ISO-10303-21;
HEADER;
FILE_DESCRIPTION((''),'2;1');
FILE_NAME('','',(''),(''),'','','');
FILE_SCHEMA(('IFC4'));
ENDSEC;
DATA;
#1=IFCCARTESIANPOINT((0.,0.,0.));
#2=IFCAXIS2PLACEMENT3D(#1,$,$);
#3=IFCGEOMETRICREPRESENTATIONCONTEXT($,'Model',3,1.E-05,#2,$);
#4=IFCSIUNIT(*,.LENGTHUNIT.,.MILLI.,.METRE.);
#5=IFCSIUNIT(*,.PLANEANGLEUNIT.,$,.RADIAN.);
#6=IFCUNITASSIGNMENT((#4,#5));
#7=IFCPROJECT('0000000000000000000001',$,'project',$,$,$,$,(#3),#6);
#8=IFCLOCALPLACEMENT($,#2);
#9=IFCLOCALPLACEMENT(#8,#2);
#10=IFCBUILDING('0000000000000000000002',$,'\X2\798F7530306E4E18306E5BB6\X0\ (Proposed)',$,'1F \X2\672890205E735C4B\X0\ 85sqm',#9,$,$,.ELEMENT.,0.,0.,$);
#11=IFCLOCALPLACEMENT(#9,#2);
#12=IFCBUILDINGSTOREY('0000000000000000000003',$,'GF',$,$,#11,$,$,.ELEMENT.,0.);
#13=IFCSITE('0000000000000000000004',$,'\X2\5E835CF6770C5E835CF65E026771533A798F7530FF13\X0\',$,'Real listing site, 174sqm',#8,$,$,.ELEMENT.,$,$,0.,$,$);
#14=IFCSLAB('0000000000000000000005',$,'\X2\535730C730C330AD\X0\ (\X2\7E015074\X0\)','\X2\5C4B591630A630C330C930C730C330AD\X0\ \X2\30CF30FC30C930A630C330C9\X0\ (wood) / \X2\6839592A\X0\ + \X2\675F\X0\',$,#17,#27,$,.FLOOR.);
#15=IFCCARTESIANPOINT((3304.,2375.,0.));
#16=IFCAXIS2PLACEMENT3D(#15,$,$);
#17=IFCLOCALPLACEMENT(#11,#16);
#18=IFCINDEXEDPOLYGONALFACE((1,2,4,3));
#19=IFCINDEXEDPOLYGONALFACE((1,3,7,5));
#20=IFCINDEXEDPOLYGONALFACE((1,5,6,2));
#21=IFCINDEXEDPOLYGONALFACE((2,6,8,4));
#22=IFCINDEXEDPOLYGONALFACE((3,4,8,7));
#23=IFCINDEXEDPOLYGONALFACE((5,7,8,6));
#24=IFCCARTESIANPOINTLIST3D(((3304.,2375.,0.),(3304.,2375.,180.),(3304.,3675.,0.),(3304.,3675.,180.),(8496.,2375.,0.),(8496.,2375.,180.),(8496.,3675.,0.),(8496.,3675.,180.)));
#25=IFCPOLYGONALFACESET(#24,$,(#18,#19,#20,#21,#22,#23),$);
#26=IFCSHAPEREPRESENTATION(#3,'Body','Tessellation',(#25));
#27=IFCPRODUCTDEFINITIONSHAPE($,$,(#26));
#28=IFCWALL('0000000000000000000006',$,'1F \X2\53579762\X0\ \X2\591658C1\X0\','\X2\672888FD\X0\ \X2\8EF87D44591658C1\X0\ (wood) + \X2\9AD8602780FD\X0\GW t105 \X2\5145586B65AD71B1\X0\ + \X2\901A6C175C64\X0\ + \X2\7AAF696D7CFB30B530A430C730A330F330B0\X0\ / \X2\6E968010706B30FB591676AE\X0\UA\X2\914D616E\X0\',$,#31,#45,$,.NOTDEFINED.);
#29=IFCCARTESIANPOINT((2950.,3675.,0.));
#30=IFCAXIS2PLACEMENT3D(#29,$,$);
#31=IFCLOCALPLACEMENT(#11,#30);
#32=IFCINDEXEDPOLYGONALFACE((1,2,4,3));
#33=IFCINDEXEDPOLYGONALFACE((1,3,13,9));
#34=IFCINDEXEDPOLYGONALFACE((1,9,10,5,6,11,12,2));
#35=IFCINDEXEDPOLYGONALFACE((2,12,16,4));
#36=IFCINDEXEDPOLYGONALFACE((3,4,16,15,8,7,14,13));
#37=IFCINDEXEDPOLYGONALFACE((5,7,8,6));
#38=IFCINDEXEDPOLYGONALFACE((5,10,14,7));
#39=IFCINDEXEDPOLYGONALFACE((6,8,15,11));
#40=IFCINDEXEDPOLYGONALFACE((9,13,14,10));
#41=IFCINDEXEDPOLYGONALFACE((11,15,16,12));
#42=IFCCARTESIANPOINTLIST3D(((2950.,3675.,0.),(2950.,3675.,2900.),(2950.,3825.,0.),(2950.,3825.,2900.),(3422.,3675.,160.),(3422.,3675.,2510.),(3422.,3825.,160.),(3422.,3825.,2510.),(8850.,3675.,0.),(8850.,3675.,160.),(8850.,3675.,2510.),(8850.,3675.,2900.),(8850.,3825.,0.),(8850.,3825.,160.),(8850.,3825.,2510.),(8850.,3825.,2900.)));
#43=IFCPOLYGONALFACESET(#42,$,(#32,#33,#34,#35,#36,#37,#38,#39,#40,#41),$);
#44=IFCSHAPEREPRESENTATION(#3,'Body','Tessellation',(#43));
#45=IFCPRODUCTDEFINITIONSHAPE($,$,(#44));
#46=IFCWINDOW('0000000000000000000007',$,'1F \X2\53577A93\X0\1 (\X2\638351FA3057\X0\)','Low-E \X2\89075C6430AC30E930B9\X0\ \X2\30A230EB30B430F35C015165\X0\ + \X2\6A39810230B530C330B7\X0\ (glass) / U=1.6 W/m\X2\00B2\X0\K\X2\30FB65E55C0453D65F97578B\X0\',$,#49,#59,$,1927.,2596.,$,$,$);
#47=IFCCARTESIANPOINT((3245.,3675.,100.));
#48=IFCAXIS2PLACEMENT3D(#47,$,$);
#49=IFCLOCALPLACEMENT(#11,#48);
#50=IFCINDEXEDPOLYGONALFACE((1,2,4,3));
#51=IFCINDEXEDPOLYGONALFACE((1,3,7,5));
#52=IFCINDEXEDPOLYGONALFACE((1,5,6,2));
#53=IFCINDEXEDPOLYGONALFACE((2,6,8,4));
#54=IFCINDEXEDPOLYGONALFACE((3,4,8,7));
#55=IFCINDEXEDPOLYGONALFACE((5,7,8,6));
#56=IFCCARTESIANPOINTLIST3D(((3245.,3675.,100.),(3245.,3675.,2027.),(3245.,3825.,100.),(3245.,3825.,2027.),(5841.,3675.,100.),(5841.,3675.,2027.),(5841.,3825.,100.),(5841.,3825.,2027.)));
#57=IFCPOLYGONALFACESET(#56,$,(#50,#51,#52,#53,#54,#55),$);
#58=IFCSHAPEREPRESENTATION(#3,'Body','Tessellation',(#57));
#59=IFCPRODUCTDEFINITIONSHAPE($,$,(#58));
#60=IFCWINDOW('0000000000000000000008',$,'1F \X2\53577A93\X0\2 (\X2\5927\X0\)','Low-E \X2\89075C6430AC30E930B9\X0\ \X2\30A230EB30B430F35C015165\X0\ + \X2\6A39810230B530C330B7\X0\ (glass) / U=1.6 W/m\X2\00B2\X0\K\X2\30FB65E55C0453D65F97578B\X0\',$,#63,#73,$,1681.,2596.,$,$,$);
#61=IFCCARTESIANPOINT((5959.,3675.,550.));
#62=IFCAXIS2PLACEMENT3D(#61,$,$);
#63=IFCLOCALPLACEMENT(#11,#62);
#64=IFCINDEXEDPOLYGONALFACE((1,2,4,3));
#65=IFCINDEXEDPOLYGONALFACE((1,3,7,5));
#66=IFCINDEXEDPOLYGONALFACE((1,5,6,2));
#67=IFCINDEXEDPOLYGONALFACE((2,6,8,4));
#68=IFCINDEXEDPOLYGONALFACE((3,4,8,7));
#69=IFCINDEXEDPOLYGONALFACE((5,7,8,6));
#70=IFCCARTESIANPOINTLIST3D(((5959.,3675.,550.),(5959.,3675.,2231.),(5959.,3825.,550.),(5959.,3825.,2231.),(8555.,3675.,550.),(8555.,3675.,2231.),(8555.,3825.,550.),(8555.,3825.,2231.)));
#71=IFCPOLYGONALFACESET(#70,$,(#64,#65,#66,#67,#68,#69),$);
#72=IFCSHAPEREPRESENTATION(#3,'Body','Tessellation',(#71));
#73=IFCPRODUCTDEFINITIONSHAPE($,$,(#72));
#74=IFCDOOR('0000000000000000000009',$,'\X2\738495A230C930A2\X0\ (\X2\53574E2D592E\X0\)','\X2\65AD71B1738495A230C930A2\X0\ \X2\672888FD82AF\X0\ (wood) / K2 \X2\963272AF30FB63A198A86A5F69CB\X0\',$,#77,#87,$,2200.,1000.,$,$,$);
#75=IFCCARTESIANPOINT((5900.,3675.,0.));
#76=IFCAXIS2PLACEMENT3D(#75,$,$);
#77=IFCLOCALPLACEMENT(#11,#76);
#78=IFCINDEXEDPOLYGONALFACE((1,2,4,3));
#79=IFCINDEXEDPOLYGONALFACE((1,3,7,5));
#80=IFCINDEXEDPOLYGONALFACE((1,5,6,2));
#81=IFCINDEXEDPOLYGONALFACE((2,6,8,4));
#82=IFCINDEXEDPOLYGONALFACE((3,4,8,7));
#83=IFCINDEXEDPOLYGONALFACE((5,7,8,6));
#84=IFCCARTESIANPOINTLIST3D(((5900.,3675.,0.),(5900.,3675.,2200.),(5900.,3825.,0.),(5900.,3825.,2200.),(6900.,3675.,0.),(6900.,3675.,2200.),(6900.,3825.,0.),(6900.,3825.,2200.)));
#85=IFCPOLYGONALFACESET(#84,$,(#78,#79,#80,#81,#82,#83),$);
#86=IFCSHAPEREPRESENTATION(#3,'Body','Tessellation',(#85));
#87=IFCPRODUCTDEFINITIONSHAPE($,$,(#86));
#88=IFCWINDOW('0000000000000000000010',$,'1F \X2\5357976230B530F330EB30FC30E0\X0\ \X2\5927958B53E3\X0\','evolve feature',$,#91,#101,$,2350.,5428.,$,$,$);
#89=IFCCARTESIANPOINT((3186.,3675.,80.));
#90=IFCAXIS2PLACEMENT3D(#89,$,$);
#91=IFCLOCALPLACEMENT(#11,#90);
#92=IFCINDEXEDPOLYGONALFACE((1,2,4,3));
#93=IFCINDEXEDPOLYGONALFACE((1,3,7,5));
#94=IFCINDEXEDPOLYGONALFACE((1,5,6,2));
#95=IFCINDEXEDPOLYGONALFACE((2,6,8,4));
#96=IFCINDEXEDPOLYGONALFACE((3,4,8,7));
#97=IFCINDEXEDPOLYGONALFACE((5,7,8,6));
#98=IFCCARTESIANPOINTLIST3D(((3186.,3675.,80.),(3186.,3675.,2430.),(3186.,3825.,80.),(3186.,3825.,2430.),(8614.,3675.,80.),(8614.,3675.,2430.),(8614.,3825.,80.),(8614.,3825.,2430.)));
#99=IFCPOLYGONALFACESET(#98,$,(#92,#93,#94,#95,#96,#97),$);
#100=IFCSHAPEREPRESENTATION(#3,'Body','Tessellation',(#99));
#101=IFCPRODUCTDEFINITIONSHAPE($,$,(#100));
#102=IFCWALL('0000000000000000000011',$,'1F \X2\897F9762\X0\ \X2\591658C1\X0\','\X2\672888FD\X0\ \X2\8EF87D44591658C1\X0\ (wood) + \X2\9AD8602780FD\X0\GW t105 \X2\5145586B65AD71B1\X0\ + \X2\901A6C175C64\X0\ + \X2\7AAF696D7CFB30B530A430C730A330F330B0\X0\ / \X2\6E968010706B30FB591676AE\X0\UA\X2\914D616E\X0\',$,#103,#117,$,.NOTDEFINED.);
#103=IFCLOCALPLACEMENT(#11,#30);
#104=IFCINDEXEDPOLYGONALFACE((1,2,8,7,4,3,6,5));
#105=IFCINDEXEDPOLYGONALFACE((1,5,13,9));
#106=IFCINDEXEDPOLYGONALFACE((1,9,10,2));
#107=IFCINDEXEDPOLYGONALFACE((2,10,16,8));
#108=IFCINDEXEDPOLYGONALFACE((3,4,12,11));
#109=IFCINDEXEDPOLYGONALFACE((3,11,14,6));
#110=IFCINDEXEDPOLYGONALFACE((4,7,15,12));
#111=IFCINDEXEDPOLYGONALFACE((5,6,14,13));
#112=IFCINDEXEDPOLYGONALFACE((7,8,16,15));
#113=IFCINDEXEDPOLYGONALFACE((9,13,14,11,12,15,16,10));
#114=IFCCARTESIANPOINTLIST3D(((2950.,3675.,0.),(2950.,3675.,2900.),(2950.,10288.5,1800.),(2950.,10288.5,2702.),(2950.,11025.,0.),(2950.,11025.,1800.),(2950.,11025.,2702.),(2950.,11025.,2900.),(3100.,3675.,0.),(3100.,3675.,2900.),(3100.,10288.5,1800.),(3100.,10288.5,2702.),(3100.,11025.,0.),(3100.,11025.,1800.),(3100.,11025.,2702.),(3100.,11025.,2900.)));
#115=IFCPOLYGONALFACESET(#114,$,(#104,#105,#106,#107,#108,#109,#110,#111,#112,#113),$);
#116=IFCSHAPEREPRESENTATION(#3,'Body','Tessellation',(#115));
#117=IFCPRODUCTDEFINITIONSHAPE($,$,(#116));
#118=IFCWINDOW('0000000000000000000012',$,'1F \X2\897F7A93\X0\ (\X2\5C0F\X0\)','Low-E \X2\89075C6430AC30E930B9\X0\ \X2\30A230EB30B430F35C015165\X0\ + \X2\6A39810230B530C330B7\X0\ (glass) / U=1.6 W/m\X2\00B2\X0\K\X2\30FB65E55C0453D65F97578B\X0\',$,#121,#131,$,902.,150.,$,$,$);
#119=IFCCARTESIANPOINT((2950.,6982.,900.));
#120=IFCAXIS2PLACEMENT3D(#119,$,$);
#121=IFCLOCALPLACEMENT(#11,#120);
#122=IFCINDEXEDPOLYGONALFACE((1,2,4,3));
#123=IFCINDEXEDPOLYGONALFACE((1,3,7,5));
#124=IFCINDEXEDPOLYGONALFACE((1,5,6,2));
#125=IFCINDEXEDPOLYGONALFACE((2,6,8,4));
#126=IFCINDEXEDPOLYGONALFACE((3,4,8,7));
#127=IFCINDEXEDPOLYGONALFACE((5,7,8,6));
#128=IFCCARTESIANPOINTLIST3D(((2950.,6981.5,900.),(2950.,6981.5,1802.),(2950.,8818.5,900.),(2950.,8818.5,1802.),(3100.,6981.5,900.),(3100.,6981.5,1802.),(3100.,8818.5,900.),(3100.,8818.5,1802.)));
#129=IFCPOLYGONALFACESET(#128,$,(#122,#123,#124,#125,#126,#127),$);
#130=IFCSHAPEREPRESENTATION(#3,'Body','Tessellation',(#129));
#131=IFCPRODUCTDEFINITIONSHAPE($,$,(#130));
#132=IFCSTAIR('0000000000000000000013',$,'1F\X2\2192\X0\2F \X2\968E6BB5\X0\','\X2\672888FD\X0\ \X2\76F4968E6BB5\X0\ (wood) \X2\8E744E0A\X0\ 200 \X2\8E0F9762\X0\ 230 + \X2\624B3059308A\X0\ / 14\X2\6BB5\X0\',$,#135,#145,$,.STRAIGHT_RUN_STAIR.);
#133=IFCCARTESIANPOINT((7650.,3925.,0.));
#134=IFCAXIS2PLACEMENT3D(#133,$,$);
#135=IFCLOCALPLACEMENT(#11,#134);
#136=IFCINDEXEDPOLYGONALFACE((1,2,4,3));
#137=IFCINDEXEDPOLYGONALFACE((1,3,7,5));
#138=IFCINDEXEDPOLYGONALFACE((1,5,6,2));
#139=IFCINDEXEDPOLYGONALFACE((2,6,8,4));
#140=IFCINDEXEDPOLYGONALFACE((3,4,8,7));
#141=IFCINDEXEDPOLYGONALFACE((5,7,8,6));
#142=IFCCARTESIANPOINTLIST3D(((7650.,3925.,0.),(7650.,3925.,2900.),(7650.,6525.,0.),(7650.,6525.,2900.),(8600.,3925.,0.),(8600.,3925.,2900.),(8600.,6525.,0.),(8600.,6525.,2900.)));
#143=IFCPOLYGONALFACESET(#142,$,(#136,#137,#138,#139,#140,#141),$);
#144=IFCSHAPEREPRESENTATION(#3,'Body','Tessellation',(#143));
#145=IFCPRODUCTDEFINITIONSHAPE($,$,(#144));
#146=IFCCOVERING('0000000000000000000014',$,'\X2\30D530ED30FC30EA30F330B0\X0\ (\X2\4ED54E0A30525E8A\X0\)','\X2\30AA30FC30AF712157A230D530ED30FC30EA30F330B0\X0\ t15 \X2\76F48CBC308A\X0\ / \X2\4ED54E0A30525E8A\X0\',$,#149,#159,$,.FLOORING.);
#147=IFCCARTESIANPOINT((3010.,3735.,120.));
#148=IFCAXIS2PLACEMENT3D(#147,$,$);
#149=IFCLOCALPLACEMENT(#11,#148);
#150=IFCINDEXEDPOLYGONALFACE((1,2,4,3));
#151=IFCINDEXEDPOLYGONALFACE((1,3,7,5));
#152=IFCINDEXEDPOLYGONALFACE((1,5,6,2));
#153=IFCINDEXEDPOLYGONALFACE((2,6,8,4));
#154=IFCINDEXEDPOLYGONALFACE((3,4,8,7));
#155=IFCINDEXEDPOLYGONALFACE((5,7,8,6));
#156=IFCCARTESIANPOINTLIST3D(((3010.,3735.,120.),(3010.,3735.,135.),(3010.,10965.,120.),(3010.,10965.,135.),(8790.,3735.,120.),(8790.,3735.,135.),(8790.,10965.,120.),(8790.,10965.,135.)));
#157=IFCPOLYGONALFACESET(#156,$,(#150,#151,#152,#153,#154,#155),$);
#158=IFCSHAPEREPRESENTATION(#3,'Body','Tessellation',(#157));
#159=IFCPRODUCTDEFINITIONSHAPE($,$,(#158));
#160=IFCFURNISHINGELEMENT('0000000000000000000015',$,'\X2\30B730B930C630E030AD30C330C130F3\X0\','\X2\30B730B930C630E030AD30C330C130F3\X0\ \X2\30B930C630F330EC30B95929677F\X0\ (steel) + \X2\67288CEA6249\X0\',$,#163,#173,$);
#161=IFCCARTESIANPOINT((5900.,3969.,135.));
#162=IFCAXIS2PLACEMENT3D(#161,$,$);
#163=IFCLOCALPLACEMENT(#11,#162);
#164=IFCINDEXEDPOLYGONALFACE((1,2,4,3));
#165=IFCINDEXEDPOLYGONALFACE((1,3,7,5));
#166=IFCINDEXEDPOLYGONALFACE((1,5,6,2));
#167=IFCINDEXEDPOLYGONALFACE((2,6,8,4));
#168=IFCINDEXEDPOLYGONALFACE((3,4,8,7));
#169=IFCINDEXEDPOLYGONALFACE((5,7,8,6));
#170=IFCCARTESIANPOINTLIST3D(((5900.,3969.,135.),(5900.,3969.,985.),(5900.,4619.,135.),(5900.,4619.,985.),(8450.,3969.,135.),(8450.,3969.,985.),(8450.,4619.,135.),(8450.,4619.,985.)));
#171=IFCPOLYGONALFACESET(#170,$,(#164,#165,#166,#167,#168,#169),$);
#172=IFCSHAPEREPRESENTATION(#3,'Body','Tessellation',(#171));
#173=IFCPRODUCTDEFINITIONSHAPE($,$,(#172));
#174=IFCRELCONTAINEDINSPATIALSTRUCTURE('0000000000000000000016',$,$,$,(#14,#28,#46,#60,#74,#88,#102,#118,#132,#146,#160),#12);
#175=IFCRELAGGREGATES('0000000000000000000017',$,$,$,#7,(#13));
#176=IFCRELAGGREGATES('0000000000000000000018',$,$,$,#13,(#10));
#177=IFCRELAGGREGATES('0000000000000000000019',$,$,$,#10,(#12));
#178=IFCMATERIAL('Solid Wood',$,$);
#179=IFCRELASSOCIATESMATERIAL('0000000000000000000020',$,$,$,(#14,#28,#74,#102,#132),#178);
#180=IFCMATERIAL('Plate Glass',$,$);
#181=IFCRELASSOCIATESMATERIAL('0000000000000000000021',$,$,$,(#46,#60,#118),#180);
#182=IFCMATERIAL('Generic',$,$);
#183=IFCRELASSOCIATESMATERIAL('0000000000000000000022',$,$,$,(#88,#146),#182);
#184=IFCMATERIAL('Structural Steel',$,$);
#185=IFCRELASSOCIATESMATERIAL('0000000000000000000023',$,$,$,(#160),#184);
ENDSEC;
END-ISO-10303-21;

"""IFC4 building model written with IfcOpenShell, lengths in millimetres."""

from ifc_helpers import new_model, si_unit, frame, frame_2d, origin, place, context, project, spatial, rectangle, extrude, material, element, fill, save


model = new_model("IFC4")

# Units and contexts
model_context = context("Model", 3, precision=1e-05, world=origin())
ifc_project = project(units=[si_unit("LENGTHUNIT", "METRE", prefix="MILLI"), si_unit("PLANEANGLEUNIT", "RADIAN")], contexts=[model_context])

# Site, building, storey
site_placement = place(None, origin())
site = spatial("IfcSite", under=ifc_project, at=site_placement, Name="広島県広島市東区福田３", ObjectType="Real listing site, 174sqm", CompositionType="ELEMENT", RefElevation=0.0)
building_placement = place(site_placement, origin())
building = spatial("IfcBuilding", under=site, at=building_placement, Name="福田の丘の家 (Proposed)", ObjectType="1F 木造平屋 85sqm", CompositionType="ELEMENT", ElevationOfRefHeight=0.0, ElevationOfTerrain=0.0)
storey_placement = place(building_placement, origin())
storey = spatial("IfcBuildingStorey", under=building, at=storey_placement, Name="GF", CompositionType="ELEMENT", Elevation=0.0)

# Slab
ifc_material_1 = material(Name="Solid Wood")
slab_1_placement = place(storey_placement, frame((3304.0, 2375.0, 0.0)))
element("IfcSlab", 1, at=slab_1_placement, inside=storey, material=ifc_material_1, Name="南デッキ (縁側)", Description="屋外ウッドデッキ ハードウッド (wood) / 根太 + 束", PredefinedType="FLOOR", context=model_context, shape_type="SweptSolid", body=[
    extrude(rectangle(XDim=5192.0, YDim=1300.0, at=frame_2d((2596.0, 650.0))), frame((3304.0, 2375.0, 0.0)), (0.0, 0.0, 1.0), 180.0),
])
ifc_material_2 = material(Name="Generic")

# Wall, openings, windows, door
wall_1_placement = place(storey_placement, frame((2950.0, 3675.0, 0.0)))
wall_1 = element("IfcWall", 2, at=wall_1_placement, inside=storey, material=ifc_material_1, Name="1F 南面 外壁", Description="木製 軸組外壁 (wood) + 高性能GW t105 充填断熱 + 通気層 + 窯業系サイディング / 準耐火・外皮UA配慮", PredefinedType="NOTDEFINED", context=model_context, shape_type="SweptSolid", body=[
    extrude(rectangle(XDim=5900.0, YDim=150.0, at=frame_2d((2950.0, 75.0))), frame((2950.0, 3675.0, 0.0)), (0.0, 0.0, 1.0), 2900.0),
])
opening_1_placement = place(storey_placement, frame((3245.0, 3675.0, 100.0)))
opening_1 = element("IfcOpeningElement", 3, at=opening_1_placement, cuts=wall_1, PredefinedType="NOTDEFINED", context=model_context, shape_type="SweptSolid", body=[
    extrude(rectangle(XDim=2596.0, YDim=150.0, at=frame_2d((1298.0, 75.0))), frame((3245.0, 3675.0, 100.0)), (0.0, 0.0, 1.0), 1927.0),
])
opening_2_placement = place(storey_placement, frame((5959.0, 3675.0, 550.0)))
opening_2 = element("IfcOpeningElement", 4, at=opening_2_placement, cuts=wall_1, PredefinedType="NOTDEFINED", context=model_context, shape_type="SweptSolid", body=[
    extrude(rectangle(XDim=2596.0, YDim=150.0, at=frame_2d((1298.0, 75.0))), frame((5959.0, 3675.0, 550.0)), (0.0, 0.0, 1.0), 1681.0),
])
opening_3_placement = place(storey_placement, frame((5900.0, 3675.0, 0.0)))
opening_3 = element("IfcOpeningElement", 5, at=opening_3_placement, cuts=wall_1, PredefinedType="NOTDEFINED", context=model_context, shape_type="SweptSolid", body=[
    extrude(rectangle(XDim=1000.0, YDim=150.0, at=frame_2d((500.0, 75.0))), frame((5900.0, 3675.0, 0.0)), (0.0, 0.0, 1.0), 2200.0),
])
opening_4_placement = place(storey_placement, frame((3186.0, 3675.0, 80.0)))
opening_4 = element("IfcOpeningElement", 6, at=opening_4_placement, cuts=wall_1, PredefinedType="NOTDEFINED", context=model_context, shape_type="SweptSolid", body=[
    extrude(rectangle(XDim=5428.0, YDim=150.0, at=frame_2d((2714.0, 75.0))), frame((3186.0, 3675.0, 80.0)), (0.0, 0.0, 1.0), 2350.0),
])
ifc_material_3 = material(Name="Plate Glass")
window_1_placement = place(storey_placement, frame((3245.0, 3675.0, 100.0)))
window_1 = element("IfcWindow", 7, at=window_1_placement, inside=storey, material=ifc_material_3, Name="1F 南窓1 (掃出し)", Description="Low-E 複層ガラス アルゴン封入 + 樹脂サッシ (glass) / U=1.6 W/m²K・日射取得型", OverallHeight=1927.0, OverallWidth=2596.0, context=model_context, shape_type="SweptSolid", body=[
    extrude(rectangle(XDim=2596.0, YDim=150.0, at=frame_2d((1298.0, 75.0))), frame((3245.0, 3675.0, 100.0)), (0.0, 0.0, 1.0), 1927.0),
])
fill(opening_1, window_1)
window_2_placement = place(storey_placement, frame((5959.0, 3675.0, 550.0)))
window_2 = element("IfcWindow", 8, at=window_2_placement, inside=storey, material=ifc_material_3, Name="1F 南窓2 (大)", Description="Low-E 複層ガラス アルゴン封入 + 樹脂サッシ (glass) / U=1.6 W/m²K・日射取得型", OverallHeight=1681.0, OverallWidth=2596.0, context=model_context, shape_type="SweptSolid", body=[
    extrude(rectangle(XDim=2596.0, YDim=150.0, at=frame_2d((1298.0, 75.0))), frame((5959.0, 3675.0, 550.0)), (0.0, 0.0, 1.0), 1681.0),
])
fill(opening_2, window_2)
door_placement = place(storey_placement, frame((5900.0, 3675.0, 0.0)))
door = element("IfcDoor", 9, at=door_placement, inside=storey, material=ifc_material_1, Name="玄関ドア (南中央)", Description="断熱玄関ドア 木製芯 (wood) / K2 防犯・採風機構", OverallHeight=2200.0, OverallWidth=1000.0, context=model_context, shape_type="SweptSolid", body=[
    extrude(rectangle(XDim=1000.0, YDim=150.0, at=frame_2d((500.0, 75.0))), frame((5900.0, 3675.0, 0.0)), (0.0, 0.0, 1.0), 2200.0),
])
fill(opening_3, door)
window_3_placement = place(storey_placement, frame((3186.0, 3675.0, 80.0)))
window_3 = element("IfcWindow", 10, at=window_3_placement, inside=storey, material=ifc_material_2, Name="1F 南面サンルーム 大開口", Description="evolve feature", OverallHeight=2350.0, OverallWidth=5428.0, context=model_context, shape_type="SweptSolid", body=[
    extrude(rectangle(XDim=5428.0, YDim=150.0, at=frame_2d((2714.0, 75.0))), frame((3186.0, 3675.0, 80.0)), (0.0, 0.0, 1.0), 2350.0),
])
fill(opening_4, window_3)

# Wall, opening, window
wall_2_placement = place(storey_placement, frame((2950.0, 3675.0, 0.0)))
wall_2 = element("IfcWall", 11, at=wall_2_placement, inside=storey, material=ifc_material_1, Name="1F 西面 外壁", Description="木製 軸組外壁 (wood) + 高性能GW t105 充填断熱 + 通気層 + 窯業系サイディング / 準耐火・外皮UA配慮", PredefinedType="NOTDEFINED", context=model_context, shape_type="SweptSolid", body=[
    extrude(rectangle(XDim=150.0, YDim=7350.0, at=frame_2d((75.0, 3675.0))), frame((2950.0, 3675.0, 0.0)), (0.0, 0.0, 1.0), 2900.0),
])
opening_5_placement = place(storey_placement, frame((2950.0, 6982.0, 900.0)))
opening_5 = element("IfcOpeningElement", 12, at=opening_5_placement, cuts=wall_2, PredefinedType="NOTDEFINED", context=model_context, shape_type="SweptSolid", body=[
    extrude(rectangle(XDim=150.0, YDim=1837.0, at=frame_2d((75.0, 918.0))), frame((2950.0, 6982.0, 900.0)), (0.0, 0.0, 1.0), 902.0),
])
window_4_placement = place(storey_placement, frame((2950.0, 6982.0, 900.0)))
window_4 = element("IfcWindow", 13, at=window_4_placement, inside=storey, material=ifc_material_3, Name="1F 西窓 (小)", Description="Low-E 複層ガラス アルゴン封入 + 樹脂サッシ (glass) / U=1.6 W/m²K・日射取得型", OverallHeight=902.0, OverallWidth=150.0, context=model_context, shape_type="SweptSolid", body=[
    extrude(rectangle(XDim=150.0, YDim=1837.0, at=frame_2d((75.0, 918.0))), frame((2950.0, 6982.0, 900.0)), (0.0, 0.0, 1.0), 902.0),
])
fill(opening_5, window_4)

# Stair
stair_placement = place(storey_placement, frame((7650.0, 3925.0, 0.0)))
element("IfcStair", 14, at=stair_placement, inside=storey, material=ifc_material_1, Name="1F→2F 階段", Description="木製 直階段 (wood) 蹴上 200 踏面 230 + 手すり / 14段", PredefinedType="STRAIGHT_RUN_STAIR", context=model_context, shape_type="SweptSolid", body=[
    extrude(rectangle(XDim=950.0, YDim=2600.0, at=frame_2d((475.0, 1300.0))), frame((7650.0, 3925.0, 0.0)), (0.0, 0.0, 1.0), 2900.0),
])

# Covering
covering_placement = place(storey_placement, frame((3010.0, 3735.0, 120.0)))
element("IfcCovering", 15, at=covering_placement, inside=storey, material=ifc_material_2, Name="フローリング (仕上げ床)", Description="オーク無垢フローリング t15 直貼り / 仕上げ床", PredefinedType="FLOORING", context=model_context, shape_type="SweptSolid", body=[
    extrude(rectangle(XDim=5780.0, YDim=7230.0, at=frame_2d((2890.0, 3615.0))), frame((3010.0, 3735.0, 120.0)), (0.0, 0.0, 1.0), 15.0),
])

# Furnishing element
ifc_material_4 = material(Name="Structural Steel")
furnishing_placement = place(storey_placement, frame((5900.0, 3969.0, 135.0)))
element("IfcFurnishingElement", 16, at=furnishing_placement, inside=storey, material=ifc_material_4, Name="システムキッチン", Description="システムキッチン ステンレス天板 (steel) + 木質扉", context=model_context, shape_type="SweptSolid", body=[
    extrude(rectangle(XDim=2550.0, YDim=650.0, at=frame_2d((1275.0, 325.0))), frame((5900.0, 3969.0, 135.0)), (0.0, 0.0, 1.0), 850.0),
])

save(model, "model.ifc")
